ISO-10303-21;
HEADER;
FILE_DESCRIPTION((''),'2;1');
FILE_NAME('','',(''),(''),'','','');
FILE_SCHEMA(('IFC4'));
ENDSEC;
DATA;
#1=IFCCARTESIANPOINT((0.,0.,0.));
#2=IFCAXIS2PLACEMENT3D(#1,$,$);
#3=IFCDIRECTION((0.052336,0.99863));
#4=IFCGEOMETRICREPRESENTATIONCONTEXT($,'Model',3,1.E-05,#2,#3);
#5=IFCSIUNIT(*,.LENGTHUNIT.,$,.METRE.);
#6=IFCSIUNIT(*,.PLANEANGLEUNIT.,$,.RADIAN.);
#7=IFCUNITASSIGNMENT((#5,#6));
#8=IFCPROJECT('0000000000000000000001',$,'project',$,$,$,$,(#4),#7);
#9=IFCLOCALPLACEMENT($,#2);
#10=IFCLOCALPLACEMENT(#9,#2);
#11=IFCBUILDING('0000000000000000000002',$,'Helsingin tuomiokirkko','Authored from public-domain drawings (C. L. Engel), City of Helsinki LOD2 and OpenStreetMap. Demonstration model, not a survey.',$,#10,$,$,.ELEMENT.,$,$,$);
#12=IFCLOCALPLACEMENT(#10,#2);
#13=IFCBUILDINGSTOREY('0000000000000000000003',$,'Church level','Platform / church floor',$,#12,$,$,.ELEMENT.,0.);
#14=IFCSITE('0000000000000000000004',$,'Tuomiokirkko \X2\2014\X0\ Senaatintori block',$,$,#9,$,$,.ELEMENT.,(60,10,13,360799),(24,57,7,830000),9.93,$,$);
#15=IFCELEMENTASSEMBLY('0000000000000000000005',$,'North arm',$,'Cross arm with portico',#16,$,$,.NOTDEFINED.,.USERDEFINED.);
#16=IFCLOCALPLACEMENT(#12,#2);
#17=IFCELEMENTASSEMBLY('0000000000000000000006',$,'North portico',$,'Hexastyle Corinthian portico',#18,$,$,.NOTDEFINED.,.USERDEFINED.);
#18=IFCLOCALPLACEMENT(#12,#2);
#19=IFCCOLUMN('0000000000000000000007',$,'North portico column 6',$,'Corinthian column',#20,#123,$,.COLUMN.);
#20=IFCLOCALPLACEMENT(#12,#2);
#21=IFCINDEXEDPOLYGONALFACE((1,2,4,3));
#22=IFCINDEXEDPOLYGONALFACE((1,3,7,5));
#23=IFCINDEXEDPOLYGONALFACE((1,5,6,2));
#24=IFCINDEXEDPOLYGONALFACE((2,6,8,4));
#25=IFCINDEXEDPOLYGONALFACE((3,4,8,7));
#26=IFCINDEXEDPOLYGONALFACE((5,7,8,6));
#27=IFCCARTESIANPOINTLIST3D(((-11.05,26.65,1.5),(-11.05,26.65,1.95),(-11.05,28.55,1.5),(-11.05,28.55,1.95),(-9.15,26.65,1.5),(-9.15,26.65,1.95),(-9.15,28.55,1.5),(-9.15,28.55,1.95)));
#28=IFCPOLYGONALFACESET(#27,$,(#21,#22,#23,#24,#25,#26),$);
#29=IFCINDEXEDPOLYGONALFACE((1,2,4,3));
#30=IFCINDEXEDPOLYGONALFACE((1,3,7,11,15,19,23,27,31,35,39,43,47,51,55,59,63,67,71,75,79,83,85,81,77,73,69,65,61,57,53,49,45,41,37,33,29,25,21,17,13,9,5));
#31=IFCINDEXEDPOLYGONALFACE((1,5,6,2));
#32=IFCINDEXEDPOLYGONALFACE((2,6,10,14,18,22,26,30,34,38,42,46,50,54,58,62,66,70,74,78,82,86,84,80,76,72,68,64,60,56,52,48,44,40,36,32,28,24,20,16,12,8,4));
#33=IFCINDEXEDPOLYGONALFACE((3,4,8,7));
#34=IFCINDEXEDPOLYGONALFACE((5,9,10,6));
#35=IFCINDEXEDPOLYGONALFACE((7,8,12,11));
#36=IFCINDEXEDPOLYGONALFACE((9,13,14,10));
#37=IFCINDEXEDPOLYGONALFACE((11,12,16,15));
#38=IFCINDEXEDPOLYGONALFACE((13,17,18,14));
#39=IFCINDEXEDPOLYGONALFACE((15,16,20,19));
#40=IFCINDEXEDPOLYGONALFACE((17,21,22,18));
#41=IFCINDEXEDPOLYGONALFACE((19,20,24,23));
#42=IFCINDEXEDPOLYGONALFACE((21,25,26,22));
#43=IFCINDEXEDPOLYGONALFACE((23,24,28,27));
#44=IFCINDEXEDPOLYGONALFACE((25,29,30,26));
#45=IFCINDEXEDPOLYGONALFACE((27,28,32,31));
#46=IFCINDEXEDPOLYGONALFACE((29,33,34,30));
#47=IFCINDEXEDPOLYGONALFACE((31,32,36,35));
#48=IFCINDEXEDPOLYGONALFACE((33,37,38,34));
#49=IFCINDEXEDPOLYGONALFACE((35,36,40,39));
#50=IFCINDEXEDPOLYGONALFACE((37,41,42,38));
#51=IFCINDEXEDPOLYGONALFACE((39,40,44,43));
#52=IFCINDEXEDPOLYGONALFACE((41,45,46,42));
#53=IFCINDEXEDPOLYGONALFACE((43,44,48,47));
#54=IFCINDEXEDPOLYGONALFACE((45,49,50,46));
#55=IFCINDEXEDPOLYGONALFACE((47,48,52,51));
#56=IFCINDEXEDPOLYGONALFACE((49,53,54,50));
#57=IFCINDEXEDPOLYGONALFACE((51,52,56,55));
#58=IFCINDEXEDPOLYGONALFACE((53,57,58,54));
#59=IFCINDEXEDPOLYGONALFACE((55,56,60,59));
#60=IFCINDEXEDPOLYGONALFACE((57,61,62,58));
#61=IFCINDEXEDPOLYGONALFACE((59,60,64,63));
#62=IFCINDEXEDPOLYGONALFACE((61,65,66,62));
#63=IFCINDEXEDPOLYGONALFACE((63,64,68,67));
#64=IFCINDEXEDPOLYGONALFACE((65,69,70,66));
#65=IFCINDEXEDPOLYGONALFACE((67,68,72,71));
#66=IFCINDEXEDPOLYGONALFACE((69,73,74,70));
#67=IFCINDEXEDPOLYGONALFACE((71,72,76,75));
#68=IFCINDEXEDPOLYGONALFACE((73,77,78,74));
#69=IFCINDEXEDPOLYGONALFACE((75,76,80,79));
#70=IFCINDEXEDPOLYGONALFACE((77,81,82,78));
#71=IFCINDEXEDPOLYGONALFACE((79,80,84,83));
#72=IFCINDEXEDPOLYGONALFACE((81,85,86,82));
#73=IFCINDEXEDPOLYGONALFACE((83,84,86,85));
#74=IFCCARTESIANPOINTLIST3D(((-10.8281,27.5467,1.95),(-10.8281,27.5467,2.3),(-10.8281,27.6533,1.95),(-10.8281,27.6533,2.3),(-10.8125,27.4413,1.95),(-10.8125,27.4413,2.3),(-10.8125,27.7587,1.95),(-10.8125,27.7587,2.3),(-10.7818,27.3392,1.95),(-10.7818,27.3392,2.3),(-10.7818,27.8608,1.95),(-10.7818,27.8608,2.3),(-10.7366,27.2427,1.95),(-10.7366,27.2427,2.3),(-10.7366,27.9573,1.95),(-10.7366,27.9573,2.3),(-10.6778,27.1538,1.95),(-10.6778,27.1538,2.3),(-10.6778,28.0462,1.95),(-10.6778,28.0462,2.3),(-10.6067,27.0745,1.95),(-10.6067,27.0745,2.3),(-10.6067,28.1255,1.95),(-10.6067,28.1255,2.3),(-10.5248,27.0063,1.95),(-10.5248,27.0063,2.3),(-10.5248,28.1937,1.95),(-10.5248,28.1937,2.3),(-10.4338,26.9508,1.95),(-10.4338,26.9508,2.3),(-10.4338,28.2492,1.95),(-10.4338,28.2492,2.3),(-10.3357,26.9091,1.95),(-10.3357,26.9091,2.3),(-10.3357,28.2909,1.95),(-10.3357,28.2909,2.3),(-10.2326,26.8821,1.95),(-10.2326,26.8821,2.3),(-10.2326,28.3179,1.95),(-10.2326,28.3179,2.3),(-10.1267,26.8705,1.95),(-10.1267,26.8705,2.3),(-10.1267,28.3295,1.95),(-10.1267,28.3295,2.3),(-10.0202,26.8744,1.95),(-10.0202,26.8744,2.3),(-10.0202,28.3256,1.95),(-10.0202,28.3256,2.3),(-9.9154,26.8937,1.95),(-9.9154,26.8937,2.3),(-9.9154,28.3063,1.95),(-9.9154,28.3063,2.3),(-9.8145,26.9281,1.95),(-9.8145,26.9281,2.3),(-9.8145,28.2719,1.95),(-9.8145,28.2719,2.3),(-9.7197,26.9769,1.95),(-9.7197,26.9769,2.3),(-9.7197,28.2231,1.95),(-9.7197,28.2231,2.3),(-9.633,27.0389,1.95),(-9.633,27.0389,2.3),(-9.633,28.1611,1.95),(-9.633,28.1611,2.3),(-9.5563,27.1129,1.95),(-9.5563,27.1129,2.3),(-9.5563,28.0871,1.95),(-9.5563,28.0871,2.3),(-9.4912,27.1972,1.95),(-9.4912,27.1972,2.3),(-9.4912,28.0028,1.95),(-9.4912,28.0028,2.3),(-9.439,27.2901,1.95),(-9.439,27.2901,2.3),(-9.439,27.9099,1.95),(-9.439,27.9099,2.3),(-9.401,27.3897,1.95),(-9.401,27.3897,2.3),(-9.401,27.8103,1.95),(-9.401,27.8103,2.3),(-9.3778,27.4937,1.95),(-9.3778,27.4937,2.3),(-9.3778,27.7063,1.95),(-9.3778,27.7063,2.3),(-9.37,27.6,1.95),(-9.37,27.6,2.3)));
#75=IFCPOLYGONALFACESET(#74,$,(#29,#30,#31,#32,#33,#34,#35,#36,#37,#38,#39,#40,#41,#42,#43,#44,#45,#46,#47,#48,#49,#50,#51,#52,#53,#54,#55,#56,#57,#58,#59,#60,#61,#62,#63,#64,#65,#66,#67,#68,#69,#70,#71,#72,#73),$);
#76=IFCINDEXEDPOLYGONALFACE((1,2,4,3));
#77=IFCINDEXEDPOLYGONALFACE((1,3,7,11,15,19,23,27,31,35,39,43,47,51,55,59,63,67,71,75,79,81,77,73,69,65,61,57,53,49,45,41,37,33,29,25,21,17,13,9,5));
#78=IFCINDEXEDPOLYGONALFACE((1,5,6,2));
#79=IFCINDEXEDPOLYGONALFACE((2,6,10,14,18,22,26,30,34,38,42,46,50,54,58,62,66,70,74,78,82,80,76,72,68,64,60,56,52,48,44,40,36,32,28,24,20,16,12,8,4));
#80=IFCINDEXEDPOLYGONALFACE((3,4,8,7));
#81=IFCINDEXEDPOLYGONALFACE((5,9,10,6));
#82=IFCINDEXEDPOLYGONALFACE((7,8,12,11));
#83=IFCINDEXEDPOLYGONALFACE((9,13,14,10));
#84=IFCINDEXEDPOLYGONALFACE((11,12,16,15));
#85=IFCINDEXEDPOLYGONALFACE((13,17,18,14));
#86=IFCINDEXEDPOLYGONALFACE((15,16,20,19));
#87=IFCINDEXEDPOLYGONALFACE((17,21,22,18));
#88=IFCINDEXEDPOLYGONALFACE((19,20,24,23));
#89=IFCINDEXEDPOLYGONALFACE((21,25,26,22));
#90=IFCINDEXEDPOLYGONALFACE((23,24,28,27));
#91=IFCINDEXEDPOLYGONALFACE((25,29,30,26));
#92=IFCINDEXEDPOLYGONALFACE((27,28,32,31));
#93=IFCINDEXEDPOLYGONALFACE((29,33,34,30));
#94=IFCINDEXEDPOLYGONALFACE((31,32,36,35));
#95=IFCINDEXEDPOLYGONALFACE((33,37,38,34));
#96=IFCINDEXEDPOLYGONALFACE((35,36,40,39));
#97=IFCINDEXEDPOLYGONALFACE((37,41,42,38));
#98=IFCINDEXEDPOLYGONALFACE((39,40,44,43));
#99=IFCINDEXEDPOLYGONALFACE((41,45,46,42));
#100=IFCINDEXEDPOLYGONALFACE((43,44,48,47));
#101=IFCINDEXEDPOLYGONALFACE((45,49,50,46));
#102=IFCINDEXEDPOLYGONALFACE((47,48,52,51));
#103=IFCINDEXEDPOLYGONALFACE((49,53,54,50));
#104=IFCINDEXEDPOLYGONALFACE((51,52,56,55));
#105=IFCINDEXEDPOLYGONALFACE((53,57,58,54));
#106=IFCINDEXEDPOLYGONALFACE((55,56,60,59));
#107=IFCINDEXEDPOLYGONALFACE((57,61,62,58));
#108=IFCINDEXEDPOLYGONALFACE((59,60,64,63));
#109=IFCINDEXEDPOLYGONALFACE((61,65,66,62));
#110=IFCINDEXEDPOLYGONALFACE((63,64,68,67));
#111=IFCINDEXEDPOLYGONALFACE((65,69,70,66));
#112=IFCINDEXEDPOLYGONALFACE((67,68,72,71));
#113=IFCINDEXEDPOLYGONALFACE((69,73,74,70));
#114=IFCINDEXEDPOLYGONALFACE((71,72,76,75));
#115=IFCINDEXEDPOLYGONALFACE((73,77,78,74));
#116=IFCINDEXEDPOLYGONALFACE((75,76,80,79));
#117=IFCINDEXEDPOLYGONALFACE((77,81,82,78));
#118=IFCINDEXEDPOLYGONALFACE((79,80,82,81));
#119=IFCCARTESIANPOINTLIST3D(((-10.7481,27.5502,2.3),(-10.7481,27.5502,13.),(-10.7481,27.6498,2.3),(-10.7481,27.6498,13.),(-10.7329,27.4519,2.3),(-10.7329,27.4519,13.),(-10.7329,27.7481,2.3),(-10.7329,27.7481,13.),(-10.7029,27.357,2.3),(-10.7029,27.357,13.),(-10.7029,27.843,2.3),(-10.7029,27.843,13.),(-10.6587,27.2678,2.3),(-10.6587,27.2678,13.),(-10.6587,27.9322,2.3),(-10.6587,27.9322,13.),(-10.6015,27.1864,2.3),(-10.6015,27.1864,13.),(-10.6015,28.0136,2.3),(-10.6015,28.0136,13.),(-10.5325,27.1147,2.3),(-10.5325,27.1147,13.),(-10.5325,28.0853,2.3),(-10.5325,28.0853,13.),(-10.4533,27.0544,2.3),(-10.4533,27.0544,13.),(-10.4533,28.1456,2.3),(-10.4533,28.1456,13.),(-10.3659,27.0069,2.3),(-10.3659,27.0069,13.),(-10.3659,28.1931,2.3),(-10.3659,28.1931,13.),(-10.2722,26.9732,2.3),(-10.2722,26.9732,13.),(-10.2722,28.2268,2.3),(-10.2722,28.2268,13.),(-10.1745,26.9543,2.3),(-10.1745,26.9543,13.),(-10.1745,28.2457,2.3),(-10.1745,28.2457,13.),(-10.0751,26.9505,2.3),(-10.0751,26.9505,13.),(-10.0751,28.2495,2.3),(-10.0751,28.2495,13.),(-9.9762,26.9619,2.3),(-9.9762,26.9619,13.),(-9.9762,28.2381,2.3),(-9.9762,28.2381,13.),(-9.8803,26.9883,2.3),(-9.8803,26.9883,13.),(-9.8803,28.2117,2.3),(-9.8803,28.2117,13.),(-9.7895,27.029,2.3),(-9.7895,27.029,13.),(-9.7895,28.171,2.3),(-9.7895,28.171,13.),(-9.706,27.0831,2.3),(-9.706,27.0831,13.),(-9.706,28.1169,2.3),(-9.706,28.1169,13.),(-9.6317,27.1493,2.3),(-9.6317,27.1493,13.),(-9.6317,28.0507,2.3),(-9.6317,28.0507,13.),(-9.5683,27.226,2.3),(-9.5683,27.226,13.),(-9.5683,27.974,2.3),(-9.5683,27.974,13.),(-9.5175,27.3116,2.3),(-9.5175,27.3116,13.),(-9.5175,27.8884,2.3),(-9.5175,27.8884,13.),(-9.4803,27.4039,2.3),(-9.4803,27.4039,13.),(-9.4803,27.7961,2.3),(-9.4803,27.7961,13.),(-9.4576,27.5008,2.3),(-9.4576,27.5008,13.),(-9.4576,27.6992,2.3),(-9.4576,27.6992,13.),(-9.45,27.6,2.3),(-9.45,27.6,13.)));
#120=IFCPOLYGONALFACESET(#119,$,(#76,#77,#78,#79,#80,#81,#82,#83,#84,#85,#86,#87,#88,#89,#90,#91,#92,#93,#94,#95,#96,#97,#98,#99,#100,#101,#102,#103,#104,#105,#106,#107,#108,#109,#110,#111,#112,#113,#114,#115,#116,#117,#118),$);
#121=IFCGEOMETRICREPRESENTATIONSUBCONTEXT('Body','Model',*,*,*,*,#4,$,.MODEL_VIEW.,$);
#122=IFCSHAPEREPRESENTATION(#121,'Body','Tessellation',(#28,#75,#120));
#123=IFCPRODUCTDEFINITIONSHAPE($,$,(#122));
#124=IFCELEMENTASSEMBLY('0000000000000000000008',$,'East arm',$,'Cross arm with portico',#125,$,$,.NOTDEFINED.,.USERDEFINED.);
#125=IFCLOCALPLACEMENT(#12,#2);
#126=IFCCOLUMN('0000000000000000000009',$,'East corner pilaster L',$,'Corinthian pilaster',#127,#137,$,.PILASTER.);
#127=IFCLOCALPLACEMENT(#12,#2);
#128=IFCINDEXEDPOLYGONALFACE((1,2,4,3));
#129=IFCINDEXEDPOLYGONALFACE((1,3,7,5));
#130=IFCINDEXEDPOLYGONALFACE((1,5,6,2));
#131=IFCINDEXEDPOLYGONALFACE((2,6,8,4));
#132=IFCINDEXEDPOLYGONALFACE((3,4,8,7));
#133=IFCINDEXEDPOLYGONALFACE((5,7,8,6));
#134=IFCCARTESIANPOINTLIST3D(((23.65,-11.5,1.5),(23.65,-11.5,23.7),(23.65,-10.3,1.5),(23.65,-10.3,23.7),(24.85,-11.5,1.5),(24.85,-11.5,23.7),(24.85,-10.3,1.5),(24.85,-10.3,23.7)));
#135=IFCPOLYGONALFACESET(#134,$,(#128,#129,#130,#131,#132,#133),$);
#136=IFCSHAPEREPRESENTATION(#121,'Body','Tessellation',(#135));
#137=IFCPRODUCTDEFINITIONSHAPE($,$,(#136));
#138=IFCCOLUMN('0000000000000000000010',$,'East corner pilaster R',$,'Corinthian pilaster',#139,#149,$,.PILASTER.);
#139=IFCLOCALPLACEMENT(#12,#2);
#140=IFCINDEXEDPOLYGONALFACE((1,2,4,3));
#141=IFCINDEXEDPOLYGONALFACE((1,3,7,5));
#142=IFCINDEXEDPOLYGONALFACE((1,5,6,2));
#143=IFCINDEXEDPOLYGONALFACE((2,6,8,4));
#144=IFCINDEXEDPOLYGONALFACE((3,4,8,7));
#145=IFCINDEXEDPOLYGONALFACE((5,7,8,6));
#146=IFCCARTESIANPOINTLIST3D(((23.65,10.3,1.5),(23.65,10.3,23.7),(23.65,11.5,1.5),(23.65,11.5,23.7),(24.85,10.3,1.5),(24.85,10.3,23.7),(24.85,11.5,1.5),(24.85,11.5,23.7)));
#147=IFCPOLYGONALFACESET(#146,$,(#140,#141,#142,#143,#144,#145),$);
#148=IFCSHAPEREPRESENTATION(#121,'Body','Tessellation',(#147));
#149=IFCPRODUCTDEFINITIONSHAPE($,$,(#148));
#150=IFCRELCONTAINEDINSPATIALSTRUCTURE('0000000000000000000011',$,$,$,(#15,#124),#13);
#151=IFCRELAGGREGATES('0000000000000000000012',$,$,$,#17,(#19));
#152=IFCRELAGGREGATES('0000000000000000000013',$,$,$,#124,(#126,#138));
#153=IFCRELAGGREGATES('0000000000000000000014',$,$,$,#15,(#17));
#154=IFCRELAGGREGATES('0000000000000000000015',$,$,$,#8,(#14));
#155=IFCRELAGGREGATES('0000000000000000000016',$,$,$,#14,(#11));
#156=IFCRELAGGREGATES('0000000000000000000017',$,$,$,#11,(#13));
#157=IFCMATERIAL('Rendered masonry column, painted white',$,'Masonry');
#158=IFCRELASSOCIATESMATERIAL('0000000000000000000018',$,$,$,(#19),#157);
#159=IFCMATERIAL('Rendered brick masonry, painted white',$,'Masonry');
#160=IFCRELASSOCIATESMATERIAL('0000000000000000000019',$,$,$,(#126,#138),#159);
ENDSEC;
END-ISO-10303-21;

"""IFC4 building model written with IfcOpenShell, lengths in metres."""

from ifc_helpers import new_model, si_unit, direction, frame, origin, origin_2d_with_axis, place, context, subcontext, project, spatial, rectangle, circle, extrude, material, element, aggregate, save


model = new_model("IFC4")

# Units and contexts
model_context = context("Model", 3, precision=1e-05, world=origin(), true_north=direction((0.052336, 0.99863)))
body_context = subcontext(model_context, "Body", "Model", "MODEL_VIEW")
ifc_project = project(units=[si_unit("LENGTHUNIT", "METRE"), si_unit("PLANEANGLEUNIT", "RADIAN")], contexts=[model_context])

# Site, building, storey
site_placement = place(None, origin())
site = spatial("IfcSite", under=ifc_project, at=site_placement, Name="Tuomiokirkko — Senaatintori block", CompositionType="ELEMENT", RefLatitude=(60, 10, 13, 360799), RefLongitude=(24, 57, 7, 830000), RefElevation=9.93)
building_placement = place(site_placement, origin())
building = spatial("IfcBuilding", under=site, at=building_placement, Name="Helsingin tuomiokirkko", Description="Authored from public-domain drawings (C. L. Engel), City of Helsinki LOD2 and OpenStreetMap. Demonstration model, not a survey.", CompositionType="ELEMENT")
storey_placement = place(building_placement, origin())
storey = spatial("IfcBuildingStorey", under=building, at=storey_placement, Name="Church level", Description="Platform / church floor", CompositionType="ELEMENT", Elevation=0.0)

# Element assemblies, column
assembly_1_placement = place(building_placement, origin())
assembly_1 = element("IfcElementAssembly", 1, at=assembly_1_placement, inside=storey, Name="North arm", ObjectType="Cross arm with portico", AssemblyPlace="NOTDEFINED", PredefinedType="USERDEFINED")
assembly_2_placement = place(building_placement, origin())
assembly_2 = element("IfcElementAssembly", 2, at=assembly_2_placement, Name="North portico", ObjectType="Hexastyle Corinthian portico", AssemblyPlace="NOTDEFINED", PredefinedType="USERDEFINED")
ifc_material_1 = material(Name="Rendered masonry column, painted white", Category="Masonry")
column_1_placement = place(building_placement, origin())
column_1 = element("IfcColumn", 3, at=column_1_placement, material=ifc_material_1, Name="North portico column 6", ObjectType="Corinthian column", PredefinedType="COLUMN", context=body_context, shape_type="SweptSolid", body=[
    extrude(rectangle(XDim=1.9, YDim=1.9, at=origin_2d_with_axis()), frame((-10.1, 27.6, 1.5)), (0.0, 0.0, 1.0), 0.45),
    extrude(circle(Radius=0.73, at=origin_2d_with_axis()), frame((-10.1, 27.6, 1.95)), (0.0, 0.0, 1.0), 0.35),
    extrude(circle(Radius=0.65, at=origin_2d_with_axis()), frame((-10.1, 27.6, 2.3)), (0.0, 0.0, 1.0), 10.7),
])

# Element assembly, columns
assembly_3_placement = place(building_placement, origin())
assembly_3 = element("IfcElementAssembly", 4, at=assembly_3_placement, inside=storey, Name="East arm", ObjectType="Cross arm with portico", AssemblyPlace="NOTDEFINED", PredefinedType="USERDEFINED")
ifc_material_2 = material(Name="Rendered brick masonry, painted white", Category="Masonry")
column_2_placement = place(building_placement, origin())
column_2 = element("IfcColumn", 5, at=column_2_placement, material=ifc_material_2, Name="East corner pilaster L", ObjectType="Corinthian pilaster", PredefinedType="PILASTER", context=body_context, shape_type="SweptSolid", body=[
    extrude(rectangle(XDim=1.2, YDim=1.2, at=origin_2d_with_axis()), frame((24.25, -10.9, 1.5)), (0.0, 0.0, 1.0), 22.2),
])
column_3_placement = place(building_placement, origin())
column_3 = element("IfcColumn", 6, at=column_3_placement, material=ifc_material_2, Name="East corner pilaster R", ObjectType="Corinthian pilaster", PredefinedType="PILASTER", context=body_context, shape_type="SweptSolid", body=[
    extrude(rectangle(XDim=1.2, YDim=1.2, at=origin_2d_with_axis()), frame((24.25, 10.9, 1.5)), (0.0, 0.0, 1.0), 22.2),
])

aggregate(assembly_2, [column_1])
aggregate(assembly_3, [column_2, column_3])

aggregate(assembly_1, [assembly_2])

save(model, "model.ifc")
